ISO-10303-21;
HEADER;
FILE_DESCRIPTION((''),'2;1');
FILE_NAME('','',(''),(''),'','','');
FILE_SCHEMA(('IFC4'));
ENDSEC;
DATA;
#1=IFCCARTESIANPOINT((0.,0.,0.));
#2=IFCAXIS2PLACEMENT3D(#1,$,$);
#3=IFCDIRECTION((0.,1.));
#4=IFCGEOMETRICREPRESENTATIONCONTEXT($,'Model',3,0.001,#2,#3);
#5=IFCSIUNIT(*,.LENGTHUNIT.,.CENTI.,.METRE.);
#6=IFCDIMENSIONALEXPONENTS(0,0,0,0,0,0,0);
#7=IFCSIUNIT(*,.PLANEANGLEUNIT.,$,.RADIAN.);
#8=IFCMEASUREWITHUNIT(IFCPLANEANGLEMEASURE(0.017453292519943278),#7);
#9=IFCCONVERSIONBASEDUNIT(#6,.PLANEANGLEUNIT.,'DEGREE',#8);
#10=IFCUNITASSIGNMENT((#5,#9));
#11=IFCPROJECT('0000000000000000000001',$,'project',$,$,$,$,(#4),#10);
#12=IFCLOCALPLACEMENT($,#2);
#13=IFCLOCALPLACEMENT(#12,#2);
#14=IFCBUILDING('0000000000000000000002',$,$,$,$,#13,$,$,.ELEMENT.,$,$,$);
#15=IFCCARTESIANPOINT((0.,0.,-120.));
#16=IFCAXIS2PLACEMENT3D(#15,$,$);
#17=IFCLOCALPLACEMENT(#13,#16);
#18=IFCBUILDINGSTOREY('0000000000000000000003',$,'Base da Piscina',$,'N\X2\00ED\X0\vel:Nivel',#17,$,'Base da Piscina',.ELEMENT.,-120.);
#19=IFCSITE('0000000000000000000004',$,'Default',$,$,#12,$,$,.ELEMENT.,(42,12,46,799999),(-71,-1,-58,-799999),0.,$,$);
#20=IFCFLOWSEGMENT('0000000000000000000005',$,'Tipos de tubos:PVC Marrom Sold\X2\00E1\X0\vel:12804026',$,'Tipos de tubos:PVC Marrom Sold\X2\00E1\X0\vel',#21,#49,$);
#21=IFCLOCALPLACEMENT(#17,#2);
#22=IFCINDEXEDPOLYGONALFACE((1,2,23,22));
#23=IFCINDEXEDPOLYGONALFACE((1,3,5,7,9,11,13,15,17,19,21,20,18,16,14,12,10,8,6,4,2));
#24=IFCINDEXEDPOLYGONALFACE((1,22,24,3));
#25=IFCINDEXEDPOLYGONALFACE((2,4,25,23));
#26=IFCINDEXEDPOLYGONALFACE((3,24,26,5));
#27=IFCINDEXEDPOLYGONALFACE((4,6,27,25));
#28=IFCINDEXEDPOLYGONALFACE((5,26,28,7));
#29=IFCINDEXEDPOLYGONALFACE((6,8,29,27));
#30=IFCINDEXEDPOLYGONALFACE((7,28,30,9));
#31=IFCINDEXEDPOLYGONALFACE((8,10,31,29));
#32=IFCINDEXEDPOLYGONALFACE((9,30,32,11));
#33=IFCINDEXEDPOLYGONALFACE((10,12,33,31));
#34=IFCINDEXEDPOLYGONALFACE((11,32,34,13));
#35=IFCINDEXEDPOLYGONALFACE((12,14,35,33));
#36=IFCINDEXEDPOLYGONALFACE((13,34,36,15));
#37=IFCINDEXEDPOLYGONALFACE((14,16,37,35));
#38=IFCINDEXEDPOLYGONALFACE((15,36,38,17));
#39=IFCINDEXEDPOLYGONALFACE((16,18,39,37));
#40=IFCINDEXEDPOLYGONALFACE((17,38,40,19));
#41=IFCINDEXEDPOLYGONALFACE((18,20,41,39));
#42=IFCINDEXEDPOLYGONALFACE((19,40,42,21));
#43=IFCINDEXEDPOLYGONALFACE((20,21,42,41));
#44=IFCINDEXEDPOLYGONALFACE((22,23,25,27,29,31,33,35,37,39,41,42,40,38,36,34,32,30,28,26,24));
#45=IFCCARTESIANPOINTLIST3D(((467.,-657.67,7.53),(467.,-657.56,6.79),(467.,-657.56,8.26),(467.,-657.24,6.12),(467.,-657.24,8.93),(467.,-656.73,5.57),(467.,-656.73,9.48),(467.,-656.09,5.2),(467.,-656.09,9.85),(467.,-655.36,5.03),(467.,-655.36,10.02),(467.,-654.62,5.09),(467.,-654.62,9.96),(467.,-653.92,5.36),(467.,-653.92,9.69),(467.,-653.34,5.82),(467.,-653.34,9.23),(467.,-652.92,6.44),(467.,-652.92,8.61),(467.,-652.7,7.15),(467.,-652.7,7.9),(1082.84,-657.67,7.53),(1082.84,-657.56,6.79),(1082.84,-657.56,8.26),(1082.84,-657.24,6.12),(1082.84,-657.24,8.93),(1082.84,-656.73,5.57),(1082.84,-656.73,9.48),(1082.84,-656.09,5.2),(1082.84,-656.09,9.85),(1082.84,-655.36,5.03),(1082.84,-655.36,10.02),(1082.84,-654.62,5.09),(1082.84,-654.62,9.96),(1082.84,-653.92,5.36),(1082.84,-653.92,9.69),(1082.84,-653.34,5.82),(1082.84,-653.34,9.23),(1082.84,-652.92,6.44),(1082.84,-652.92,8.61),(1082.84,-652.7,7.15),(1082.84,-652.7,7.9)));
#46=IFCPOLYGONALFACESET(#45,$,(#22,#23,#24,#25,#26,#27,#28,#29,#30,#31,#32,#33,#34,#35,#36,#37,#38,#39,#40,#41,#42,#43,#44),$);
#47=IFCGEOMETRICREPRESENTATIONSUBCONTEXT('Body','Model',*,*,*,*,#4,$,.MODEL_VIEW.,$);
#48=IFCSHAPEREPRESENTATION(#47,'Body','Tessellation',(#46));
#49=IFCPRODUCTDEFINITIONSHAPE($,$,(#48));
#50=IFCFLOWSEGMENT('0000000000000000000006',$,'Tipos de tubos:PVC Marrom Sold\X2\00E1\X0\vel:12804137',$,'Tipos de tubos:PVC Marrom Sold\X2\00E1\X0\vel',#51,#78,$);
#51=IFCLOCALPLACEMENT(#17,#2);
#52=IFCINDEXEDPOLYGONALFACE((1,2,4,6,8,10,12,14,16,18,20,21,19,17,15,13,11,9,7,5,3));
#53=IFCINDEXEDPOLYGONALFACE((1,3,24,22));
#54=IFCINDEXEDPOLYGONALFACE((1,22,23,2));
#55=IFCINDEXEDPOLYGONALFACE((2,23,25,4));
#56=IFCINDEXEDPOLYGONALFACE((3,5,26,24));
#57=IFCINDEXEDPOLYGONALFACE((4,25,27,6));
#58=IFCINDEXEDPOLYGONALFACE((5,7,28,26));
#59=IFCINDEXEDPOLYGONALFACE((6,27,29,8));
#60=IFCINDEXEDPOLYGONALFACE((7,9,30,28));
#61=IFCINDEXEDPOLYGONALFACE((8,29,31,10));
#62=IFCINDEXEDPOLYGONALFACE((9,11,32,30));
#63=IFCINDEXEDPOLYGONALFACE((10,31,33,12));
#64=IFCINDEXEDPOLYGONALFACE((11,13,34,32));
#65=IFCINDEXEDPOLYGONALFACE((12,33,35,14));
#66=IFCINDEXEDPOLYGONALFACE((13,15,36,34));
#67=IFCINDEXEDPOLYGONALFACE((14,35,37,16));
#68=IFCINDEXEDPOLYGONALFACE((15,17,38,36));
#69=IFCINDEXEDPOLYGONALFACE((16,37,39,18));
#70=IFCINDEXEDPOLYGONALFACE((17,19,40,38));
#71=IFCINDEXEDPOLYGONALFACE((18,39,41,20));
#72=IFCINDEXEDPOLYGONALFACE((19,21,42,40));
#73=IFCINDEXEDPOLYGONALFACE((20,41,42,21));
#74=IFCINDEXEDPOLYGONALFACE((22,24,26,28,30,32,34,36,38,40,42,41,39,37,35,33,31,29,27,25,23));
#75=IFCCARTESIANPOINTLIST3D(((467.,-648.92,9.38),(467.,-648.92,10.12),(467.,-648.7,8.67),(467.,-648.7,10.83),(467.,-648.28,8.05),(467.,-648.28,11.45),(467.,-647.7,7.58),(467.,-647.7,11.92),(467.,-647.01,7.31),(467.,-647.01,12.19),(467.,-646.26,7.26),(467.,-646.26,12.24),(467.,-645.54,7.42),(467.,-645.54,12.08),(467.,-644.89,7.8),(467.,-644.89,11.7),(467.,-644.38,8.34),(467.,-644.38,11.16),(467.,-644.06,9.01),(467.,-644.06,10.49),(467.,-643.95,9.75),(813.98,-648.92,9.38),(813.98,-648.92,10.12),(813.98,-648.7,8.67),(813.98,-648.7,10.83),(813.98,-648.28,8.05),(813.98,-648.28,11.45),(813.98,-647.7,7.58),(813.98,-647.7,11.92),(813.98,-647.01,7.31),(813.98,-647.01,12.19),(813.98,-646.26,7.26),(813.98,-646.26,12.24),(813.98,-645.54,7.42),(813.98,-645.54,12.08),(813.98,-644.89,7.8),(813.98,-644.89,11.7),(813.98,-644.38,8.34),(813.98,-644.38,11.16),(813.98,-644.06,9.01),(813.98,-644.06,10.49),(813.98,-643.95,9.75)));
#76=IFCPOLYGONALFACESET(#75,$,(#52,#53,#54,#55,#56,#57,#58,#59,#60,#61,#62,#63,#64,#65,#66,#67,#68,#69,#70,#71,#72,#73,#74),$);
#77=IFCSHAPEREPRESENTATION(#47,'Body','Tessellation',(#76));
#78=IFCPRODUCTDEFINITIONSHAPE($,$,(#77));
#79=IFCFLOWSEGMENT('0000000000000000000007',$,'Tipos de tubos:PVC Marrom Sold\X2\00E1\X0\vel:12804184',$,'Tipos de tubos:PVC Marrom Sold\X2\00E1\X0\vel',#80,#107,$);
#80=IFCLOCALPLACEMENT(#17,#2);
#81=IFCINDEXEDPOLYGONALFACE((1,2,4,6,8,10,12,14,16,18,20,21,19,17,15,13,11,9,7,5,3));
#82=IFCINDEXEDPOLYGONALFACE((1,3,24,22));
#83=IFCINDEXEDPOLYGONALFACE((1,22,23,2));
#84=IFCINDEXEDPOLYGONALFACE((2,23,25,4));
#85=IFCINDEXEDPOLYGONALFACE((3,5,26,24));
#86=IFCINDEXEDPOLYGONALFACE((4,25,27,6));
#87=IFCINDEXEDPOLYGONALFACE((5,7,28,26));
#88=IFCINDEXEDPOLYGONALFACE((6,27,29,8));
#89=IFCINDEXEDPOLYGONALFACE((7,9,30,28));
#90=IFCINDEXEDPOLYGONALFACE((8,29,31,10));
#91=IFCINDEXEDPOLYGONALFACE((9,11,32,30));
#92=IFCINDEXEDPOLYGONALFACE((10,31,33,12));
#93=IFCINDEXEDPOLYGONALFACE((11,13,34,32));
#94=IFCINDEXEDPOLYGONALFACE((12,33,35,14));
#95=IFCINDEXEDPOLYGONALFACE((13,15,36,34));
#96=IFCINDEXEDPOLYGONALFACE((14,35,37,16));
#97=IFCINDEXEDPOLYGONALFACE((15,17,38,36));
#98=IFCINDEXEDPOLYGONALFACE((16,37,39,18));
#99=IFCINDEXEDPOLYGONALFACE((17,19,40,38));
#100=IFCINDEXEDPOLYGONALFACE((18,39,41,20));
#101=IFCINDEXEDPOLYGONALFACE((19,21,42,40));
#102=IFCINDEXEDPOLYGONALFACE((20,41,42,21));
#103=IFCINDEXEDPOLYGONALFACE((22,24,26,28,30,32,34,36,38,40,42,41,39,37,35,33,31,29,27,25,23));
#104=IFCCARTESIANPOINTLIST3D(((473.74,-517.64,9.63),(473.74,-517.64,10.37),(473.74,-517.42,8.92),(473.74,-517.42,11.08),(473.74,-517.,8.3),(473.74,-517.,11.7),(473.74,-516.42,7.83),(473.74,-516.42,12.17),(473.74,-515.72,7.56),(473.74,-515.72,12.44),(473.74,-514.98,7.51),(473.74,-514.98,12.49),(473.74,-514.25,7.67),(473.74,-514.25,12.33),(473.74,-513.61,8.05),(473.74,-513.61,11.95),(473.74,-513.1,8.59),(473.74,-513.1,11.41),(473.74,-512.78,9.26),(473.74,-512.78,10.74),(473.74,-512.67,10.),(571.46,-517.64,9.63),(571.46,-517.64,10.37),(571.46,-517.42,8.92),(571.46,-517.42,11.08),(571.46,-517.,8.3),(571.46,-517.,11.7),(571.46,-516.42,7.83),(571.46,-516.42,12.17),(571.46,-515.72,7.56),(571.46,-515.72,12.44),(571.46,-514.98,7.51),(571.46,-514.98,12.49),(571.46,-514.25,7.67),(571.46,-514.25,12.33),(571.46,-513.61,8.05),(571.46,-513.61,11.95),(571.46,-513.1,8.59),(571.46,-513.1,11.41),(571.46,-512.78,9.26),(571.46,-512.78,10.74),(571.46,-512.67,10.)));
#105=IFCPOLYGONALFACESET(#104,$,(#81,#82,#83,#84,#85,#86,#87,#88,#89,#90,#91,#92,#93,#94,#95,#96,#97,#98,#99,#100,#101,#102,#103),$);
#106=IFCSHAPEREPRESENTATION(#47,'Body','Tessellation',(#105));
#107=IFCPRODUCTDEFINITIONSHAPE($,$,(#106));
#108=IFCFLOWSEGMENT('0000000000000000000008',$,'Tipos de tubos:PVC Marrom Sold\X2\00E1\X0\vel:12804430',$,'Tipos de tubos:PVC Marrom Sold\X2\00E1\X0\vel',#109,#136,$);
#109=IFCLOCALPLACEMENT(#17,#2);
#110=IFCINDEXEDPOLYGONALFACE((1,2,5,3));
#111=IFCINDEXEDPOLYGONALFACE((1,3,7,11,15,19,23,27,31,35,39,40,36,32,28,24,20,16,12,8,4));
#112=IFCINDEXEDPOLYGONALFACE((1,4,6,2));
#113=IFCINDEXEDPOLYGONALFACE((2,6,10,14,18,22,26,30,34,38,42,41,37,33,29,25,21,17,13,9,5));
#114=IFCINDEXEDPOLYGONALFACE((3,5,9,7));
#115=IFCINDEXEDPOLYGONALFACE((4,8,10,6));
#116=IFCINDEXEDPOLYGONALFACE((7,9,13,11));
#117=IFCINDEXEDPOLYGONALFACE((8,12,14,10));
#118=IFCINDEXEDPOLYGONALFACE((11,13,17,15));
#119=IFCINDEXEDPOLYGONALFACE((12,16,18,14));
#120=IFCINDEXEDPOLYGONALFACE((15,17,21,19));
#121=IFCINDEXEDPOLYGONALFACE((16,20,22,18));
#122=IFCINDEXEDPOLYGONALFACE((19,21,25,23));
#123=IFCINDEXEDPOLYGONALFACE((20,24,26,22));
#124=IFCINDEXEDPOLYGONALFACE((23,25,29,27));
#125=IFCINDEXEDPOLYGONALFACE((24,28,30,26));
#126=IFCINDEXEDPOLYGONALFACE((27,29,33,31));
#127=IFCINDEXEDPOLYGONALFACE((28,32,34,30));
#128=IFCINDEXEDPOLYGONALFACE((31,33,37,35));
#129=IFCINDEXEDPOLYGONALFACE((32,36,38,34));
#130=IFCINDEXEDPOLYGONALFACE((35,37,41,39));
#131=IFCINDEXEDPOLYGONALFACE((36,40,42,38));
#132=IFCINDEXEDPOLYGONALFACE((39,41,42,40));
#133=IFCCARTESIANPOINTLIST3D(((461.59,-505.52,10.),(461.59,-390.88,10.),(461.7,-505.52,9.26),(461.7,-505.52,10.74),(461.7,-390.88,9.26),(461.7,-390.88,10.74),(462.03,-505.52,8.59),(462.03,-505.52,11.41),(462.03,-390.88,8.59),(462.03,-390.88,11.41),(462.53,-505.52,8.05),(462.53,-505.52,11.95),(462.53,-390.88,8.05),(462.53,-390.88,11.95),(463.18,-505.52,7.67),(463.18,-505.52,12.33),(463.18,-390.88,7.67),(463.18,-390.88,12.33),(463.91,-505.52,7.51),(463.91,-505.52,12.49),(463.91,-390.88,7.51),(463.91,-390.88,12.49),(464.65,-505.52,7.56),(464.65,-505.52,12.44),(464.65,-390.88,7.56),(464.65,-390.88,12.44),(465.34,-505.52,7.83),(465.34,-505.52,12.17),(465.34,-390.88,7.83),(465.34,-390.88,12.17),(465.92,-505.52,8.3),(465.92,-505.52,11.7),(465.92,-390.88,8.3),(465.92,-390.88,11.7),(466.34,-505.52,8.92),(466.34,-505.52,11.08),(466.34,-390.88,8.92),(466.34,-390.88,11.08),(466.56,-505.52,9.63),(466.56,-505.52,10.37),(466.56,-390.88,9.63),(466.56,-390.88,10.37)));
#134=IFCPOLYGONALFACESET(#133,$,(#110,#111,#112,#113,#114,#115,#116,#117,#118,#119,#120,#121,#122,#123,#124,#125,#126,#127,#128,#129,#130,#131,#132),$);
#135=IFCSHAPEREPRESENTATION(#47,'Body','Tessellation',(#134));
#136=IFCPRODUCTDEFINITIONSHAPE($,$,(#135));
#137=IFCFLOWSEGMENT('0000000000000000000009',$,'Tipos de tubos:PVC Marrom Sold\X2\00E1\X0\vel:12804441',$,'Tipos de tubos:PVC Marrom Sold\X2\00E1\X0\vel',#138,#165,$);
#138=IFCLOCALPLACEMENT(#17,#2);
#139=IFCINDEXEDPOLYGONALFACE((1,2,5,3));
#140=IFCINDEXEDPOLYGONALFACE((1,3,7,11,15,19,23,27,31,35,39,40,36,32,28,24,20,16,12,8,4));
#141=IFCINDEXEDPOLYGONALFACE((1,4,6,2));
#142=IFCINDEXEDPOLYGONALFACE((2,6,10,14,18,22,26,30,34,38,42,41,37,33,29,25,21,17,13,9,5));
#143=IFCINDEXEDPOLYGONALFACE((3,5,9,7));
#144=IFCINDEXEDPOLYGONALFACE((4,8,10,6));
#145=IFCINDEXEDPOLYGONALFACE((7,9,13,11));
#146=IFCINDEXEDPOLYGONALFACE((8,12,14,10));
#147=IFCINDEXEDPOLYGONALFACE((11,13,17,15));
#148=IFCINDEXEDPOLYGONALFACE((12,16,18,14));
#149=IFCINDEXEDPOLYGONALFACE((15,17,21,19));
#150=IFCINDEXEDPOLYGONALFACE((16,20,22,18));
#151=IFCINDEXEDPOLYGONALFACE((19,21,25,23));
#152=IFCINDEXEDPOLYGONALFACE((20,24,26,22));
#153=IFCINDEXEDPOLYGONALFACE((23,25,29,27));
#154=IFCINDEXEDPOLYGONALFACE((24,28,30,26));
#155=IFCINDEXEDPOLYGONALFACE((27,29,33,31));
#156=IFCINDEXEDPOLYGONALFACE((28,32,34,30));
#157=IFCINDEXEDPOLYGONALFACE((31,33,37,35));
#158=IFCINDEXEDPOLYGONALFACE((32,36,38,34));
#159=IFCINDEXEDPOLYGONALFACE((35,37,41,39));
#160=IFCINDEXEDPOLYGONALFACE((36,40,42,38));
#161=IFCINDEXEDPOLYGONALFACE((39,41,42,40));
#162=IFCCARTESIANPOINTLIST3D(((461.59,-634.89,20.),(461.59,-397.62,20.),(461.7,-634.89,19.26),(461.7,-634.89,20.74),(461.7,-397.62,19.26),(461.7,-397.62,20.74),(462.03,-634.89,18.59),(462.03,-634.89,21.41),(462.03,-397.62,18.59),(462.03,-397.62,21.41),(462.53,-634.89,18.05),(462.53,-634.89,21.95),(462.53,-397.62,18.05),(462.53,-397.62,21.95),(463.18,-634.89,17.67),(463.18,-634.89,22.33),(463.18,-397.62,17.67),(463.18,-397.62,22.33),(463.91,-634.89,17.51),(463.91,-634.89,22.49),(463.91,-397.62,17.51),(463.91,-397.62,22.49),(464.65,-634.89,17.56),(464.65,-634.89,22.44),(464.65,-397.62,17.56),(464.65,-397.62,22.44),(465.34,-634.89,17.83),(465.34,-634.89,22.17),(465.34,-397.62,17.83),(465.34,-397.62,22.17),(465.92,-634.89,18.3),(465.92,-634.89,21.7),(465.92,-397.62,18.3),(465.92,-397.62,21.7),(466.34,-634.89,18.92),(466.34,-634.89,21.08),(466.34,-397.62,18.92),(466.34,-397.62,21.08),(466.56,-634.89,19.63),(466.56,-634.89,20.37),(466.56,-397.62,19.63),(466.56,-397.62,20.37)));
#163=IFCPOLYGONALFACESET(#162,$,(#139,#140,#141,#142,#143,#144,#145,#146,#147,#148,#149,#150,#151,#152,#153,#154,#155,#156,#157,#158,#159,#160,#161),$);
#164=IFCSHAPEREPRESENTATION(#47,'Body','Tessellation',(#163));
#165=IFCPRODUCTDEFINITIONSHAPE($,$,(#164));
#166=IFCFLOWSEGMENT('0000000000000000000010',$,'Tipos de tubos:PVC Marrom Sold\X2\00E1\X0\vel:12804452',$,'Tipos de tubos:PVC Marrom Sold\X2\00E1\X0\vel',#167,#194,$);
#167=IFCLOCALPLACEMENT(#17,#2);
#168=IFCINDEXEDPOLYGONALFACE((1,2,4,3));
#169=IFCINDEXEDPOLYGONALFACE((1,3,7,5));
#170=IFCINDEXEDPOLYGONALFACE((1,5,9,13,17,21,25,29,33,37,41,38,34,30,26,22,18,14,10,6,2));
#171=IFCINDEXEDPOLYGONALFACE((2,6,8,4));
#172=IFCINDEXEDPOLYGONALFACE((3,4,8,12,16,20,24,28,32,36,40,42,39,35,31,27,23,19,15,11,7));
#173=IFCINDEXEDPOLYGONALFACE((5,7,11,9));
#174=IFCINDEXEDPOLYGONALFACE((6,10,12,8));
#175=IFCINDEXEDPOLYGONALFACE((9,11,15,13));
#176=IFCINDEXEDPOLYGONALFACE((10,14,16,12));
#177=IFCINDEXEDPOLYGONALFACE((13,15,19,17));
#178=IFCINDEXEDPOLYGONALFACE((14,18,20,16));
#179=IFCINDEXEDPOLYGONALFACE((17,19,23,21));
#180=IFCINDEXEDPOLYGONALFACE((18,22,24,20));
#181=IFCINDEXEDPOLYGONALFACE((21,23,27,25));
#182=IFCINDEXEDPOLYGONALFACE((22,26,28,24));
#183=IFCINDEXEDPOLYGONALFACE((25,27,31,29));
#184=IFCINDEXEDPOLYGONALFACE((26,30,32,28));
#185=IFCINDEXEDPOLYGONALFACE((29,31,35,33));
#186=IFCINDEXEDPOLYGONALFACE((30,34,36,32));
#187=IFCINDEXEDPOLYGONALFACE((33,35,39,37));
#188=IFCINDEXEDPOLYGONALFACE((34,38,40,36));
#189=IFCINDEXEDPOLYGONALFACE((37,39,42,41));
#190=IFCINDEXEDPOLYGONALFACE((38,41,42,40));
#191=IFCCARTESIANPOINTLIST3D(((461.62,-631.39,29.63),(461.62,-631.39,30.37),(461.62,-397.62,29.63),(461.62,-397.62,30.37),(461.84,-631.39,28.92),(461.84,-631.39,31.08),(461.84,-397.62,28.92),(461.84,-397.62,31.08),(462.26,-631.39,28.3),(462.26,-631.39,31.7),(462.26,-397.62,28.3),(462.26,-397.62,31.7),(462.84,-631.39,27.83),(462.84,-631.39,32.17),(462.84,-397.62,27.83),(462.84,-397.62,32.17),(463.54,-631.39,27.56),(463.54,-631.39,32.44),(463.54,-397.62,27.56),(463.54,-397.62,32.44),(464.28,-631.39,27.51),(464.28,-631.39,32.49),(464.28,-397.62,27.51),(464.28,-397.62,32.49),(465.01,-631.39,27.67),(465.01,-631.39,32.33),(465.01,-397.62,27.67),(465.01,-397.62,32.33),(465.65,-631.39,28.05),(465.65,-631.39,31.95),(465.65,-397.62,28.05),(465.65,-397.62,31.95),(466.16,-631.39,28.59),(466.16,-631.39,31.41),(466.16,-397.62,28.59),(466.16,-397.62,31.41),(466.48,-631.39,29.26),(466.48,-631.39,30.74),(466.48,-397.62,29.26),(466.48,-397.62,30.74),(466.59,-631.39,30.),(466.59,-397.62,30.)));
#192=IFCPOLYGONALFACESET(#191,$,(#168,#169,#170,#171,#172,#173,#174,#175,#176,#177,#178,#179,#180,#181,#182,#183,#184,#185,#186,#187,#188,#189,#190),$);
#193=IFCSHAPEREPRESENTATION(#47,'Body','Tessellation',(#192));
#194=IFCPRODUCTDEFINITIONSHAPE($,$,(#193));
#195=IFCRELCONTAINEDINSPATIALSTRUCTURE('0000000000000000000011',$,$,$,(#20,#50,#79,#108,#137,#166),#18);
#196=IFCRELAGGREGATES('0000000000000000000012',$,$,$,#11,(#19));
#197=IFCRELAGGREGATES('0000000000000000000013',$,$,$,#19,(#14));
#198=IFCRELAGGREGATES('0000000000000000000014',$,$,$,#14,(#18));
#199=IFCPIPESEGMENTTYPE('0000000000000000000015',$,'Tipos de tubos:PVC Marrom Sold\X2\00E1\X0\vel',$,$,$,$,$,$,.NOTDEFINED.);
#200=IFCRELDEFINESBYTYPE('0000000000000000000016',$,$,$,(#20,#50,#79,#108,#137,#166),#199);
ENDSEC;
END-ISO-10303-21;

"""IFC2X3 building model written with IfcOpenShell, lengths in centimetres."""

from ifc_helpers import new_model, entity, si_unit, converted_unit, direction, frame, frame_2d, origin, origin_2d_with_axis, place, context, subcontext, project, spatial, circle, extrude, type_object, element, save


model = new_model("IFC2X3")

# Units and contexts
model_context = context("Model", 3, precision=0.001, world=origin(), true_north=direction((0.0, 1.0)))
body_context = subcontext(model_context, "Body", "Model", "MODEL_VIEW")
ifc_project = project(units=[si_unit("LENGTHUNIT", "METRE", prefix="CENTI"), converted_unit("PLANEANGLEUNIT", "DEGREE", entity("IfcPlaneAngleMeasure", 0.017453292519943278), si_unit("PLANEANGLEUNIT", "RADIAN"), dimensions=[0, 0, 0, 0, 0, 0, 0])], contexts=[model_context])

# Site, building, storey
site_placement = place(None, origin())
site = spatial("IfcSite", under=ifc_project, at=site_placement, Name="Default", CompositionType="ELEMENT", RefLatitude=(42, 12, 46, 799999), RefLongitude=(-71, -1, -58, -799999), RefElevation=0.0)
building_placement = place(site_placement, origin())
building = spatial("IfcBuilding", under=site, at=building_placement, CompositionType="ELEMENT")
storey_placement = place(building_placement, frame((0.0, 0.0, -120.0)))
storey = spatial("IfcBuildingStorey", under=building, at=storey_placement, Name="Base da Piscina", ObjectType="Nível:Nivel", LongName="Base da Piscina", CompositionType="ELEMENT", Elevation=-120.0)

# Flow segments
pipe_segment_type = type_object("IfcPipeSegmentType", Name="Tipos de tubos:PVC Marrom Soldável", PredefinedType="NOTDEFINED")
flow_segment_1_placement = place(storey_placement, origin())
element("IfcFlowSegment", 1, at=flow_segment_1_placement, inside=storey, type_object=pipe_segment_type, Name="Tipos de tubos:PVC Marrom Soldável:12804026", ObjectType="Tipos de tubos:PVC Marrom Soldável", context=body_context, shape_type="SweptSolid", body=[
    extrude(circle(Radius=2.5, at=origin_2d_with_axis()), frame((467.0, -655.17, 7.53), z_axis=(1.0, 0.0, 0.0), x_axis=(0.0, -1.0, 0.0)), (0.0, 0.0, 1.0), 615.84),
])
flow_segment_2_placement = place(storey_placement, origin())
element("IfcFlowSegment", 2, at=flow_segment_2_placement, inside=storey, type_object=pipe_segment_type, Name="Tipos de tubos:PVC Marrom Soldável:12804137", ObjectType="Tipos de tubos:PVC Marrom Soldável", context=body_context, shape_type="SweptSolid", body=[
    extrude(circle(Radius=2.5, at=origin_2d_with_axis()), frame((467.0, -646.45, 9.75), z_axis=(1.0, 0.0, 0.0), x_axis=(0.0, 1.0, 0.0)), (0.0, 0.0, 1.0), 346.98),
])
flow_segment_3_placement = place(storey_placement, origin())
element("IfcFlowSegment", 3, at=flow_segment_3_placement, inside=storey, type_object=pipe_segment_type, Name="Tipos de tubos:PVC Marrom Soldável:12804184", ObjectType="Tipos de tubos:PVC Marrom Soldável", context=body_context, shape_type="SweptSolid", body=[
    extrude(circle(Radius=2.5, at=frame_2d((0.0, 0.0), x_axis=(1.0, 0.0))), frame((473.74, -515.17, 10.0), z_axis=(1.0, 0.0, 0.0), x_axis=(0.0, 1.0, 0.0)), (0.0, 0.0, 1.0), 97.72),
])
flow_segment_4_placement = place(storey_placement, origin())
element("IfcFlowSegment", 4, at=flow_segment_4_placement, inside=storey, type_object=pipe_segment_type, Name="Tipos de tubos:PVC Marrom Soldável:12804430", ObjectType="Tipos de tubos:PVC Marrom Soldável", context=body_context, shape_type="SweptSolid", body=[
    extrude(circle(Radius=2.5, at=frame_2d((0.0, 0.0), x_axis=(1.0, 0.0))), frame((464.09, -505.52, 10.0), z_axis=(0.0, 1.0, 0.0), x_axis=(-1.0, 0.0, 0.0)), (0.0, 0.0, 1.0), 114.64),
])
flow_segment_5_placement = place(storey_placement, origin())
element("IfcFlowSegment", 5, at=flow_segment_5_placement, inside=storey, type_object=pipe_segment_type, Name="Tipos de tubos:PVC Marrom Soldável:12804441", ObjectType="Tipos de tubos:PVC Marrom Soldável", context=body_context, shape_type="SweptSolid", body=[
    extrude(circle(Radius=2.5, at=frame_2d((0.0, 0.0), x_axis=(1.0, 0.0))), frame((464.09, -634.89, 20.0), z_axis=(0.0, 1.0, 0.0), x_axis=(-1.0, 0.0, 0.0)), (0.0, 0.0, 1.0), 237.28),
])
flow_segment_6_placement = place(storey_placement, origin())
element("IfcFlowSegment", 6, at=flow_segment_6_placement, inside=storey, type_object=pipe_segment_type, Name="Tipos de tubos:PVC Marrom Soldável:12804452", ObjectType="Tipos de tubos:PVC Marrom Soldável", context=body_context, shape_type="SweptSolid", body=[
    extrude(circle(Radius=2.5, at=origin_2d_with_axis()), frame((464.09, -631.39, 30.0), z_axis=(0.0, 1.0, 0.0), x_axis=(1.0, 0.0, 0.0)), (0.0, 0.0, 1.0), 233.78),
])

save(model, "model.ifc")
